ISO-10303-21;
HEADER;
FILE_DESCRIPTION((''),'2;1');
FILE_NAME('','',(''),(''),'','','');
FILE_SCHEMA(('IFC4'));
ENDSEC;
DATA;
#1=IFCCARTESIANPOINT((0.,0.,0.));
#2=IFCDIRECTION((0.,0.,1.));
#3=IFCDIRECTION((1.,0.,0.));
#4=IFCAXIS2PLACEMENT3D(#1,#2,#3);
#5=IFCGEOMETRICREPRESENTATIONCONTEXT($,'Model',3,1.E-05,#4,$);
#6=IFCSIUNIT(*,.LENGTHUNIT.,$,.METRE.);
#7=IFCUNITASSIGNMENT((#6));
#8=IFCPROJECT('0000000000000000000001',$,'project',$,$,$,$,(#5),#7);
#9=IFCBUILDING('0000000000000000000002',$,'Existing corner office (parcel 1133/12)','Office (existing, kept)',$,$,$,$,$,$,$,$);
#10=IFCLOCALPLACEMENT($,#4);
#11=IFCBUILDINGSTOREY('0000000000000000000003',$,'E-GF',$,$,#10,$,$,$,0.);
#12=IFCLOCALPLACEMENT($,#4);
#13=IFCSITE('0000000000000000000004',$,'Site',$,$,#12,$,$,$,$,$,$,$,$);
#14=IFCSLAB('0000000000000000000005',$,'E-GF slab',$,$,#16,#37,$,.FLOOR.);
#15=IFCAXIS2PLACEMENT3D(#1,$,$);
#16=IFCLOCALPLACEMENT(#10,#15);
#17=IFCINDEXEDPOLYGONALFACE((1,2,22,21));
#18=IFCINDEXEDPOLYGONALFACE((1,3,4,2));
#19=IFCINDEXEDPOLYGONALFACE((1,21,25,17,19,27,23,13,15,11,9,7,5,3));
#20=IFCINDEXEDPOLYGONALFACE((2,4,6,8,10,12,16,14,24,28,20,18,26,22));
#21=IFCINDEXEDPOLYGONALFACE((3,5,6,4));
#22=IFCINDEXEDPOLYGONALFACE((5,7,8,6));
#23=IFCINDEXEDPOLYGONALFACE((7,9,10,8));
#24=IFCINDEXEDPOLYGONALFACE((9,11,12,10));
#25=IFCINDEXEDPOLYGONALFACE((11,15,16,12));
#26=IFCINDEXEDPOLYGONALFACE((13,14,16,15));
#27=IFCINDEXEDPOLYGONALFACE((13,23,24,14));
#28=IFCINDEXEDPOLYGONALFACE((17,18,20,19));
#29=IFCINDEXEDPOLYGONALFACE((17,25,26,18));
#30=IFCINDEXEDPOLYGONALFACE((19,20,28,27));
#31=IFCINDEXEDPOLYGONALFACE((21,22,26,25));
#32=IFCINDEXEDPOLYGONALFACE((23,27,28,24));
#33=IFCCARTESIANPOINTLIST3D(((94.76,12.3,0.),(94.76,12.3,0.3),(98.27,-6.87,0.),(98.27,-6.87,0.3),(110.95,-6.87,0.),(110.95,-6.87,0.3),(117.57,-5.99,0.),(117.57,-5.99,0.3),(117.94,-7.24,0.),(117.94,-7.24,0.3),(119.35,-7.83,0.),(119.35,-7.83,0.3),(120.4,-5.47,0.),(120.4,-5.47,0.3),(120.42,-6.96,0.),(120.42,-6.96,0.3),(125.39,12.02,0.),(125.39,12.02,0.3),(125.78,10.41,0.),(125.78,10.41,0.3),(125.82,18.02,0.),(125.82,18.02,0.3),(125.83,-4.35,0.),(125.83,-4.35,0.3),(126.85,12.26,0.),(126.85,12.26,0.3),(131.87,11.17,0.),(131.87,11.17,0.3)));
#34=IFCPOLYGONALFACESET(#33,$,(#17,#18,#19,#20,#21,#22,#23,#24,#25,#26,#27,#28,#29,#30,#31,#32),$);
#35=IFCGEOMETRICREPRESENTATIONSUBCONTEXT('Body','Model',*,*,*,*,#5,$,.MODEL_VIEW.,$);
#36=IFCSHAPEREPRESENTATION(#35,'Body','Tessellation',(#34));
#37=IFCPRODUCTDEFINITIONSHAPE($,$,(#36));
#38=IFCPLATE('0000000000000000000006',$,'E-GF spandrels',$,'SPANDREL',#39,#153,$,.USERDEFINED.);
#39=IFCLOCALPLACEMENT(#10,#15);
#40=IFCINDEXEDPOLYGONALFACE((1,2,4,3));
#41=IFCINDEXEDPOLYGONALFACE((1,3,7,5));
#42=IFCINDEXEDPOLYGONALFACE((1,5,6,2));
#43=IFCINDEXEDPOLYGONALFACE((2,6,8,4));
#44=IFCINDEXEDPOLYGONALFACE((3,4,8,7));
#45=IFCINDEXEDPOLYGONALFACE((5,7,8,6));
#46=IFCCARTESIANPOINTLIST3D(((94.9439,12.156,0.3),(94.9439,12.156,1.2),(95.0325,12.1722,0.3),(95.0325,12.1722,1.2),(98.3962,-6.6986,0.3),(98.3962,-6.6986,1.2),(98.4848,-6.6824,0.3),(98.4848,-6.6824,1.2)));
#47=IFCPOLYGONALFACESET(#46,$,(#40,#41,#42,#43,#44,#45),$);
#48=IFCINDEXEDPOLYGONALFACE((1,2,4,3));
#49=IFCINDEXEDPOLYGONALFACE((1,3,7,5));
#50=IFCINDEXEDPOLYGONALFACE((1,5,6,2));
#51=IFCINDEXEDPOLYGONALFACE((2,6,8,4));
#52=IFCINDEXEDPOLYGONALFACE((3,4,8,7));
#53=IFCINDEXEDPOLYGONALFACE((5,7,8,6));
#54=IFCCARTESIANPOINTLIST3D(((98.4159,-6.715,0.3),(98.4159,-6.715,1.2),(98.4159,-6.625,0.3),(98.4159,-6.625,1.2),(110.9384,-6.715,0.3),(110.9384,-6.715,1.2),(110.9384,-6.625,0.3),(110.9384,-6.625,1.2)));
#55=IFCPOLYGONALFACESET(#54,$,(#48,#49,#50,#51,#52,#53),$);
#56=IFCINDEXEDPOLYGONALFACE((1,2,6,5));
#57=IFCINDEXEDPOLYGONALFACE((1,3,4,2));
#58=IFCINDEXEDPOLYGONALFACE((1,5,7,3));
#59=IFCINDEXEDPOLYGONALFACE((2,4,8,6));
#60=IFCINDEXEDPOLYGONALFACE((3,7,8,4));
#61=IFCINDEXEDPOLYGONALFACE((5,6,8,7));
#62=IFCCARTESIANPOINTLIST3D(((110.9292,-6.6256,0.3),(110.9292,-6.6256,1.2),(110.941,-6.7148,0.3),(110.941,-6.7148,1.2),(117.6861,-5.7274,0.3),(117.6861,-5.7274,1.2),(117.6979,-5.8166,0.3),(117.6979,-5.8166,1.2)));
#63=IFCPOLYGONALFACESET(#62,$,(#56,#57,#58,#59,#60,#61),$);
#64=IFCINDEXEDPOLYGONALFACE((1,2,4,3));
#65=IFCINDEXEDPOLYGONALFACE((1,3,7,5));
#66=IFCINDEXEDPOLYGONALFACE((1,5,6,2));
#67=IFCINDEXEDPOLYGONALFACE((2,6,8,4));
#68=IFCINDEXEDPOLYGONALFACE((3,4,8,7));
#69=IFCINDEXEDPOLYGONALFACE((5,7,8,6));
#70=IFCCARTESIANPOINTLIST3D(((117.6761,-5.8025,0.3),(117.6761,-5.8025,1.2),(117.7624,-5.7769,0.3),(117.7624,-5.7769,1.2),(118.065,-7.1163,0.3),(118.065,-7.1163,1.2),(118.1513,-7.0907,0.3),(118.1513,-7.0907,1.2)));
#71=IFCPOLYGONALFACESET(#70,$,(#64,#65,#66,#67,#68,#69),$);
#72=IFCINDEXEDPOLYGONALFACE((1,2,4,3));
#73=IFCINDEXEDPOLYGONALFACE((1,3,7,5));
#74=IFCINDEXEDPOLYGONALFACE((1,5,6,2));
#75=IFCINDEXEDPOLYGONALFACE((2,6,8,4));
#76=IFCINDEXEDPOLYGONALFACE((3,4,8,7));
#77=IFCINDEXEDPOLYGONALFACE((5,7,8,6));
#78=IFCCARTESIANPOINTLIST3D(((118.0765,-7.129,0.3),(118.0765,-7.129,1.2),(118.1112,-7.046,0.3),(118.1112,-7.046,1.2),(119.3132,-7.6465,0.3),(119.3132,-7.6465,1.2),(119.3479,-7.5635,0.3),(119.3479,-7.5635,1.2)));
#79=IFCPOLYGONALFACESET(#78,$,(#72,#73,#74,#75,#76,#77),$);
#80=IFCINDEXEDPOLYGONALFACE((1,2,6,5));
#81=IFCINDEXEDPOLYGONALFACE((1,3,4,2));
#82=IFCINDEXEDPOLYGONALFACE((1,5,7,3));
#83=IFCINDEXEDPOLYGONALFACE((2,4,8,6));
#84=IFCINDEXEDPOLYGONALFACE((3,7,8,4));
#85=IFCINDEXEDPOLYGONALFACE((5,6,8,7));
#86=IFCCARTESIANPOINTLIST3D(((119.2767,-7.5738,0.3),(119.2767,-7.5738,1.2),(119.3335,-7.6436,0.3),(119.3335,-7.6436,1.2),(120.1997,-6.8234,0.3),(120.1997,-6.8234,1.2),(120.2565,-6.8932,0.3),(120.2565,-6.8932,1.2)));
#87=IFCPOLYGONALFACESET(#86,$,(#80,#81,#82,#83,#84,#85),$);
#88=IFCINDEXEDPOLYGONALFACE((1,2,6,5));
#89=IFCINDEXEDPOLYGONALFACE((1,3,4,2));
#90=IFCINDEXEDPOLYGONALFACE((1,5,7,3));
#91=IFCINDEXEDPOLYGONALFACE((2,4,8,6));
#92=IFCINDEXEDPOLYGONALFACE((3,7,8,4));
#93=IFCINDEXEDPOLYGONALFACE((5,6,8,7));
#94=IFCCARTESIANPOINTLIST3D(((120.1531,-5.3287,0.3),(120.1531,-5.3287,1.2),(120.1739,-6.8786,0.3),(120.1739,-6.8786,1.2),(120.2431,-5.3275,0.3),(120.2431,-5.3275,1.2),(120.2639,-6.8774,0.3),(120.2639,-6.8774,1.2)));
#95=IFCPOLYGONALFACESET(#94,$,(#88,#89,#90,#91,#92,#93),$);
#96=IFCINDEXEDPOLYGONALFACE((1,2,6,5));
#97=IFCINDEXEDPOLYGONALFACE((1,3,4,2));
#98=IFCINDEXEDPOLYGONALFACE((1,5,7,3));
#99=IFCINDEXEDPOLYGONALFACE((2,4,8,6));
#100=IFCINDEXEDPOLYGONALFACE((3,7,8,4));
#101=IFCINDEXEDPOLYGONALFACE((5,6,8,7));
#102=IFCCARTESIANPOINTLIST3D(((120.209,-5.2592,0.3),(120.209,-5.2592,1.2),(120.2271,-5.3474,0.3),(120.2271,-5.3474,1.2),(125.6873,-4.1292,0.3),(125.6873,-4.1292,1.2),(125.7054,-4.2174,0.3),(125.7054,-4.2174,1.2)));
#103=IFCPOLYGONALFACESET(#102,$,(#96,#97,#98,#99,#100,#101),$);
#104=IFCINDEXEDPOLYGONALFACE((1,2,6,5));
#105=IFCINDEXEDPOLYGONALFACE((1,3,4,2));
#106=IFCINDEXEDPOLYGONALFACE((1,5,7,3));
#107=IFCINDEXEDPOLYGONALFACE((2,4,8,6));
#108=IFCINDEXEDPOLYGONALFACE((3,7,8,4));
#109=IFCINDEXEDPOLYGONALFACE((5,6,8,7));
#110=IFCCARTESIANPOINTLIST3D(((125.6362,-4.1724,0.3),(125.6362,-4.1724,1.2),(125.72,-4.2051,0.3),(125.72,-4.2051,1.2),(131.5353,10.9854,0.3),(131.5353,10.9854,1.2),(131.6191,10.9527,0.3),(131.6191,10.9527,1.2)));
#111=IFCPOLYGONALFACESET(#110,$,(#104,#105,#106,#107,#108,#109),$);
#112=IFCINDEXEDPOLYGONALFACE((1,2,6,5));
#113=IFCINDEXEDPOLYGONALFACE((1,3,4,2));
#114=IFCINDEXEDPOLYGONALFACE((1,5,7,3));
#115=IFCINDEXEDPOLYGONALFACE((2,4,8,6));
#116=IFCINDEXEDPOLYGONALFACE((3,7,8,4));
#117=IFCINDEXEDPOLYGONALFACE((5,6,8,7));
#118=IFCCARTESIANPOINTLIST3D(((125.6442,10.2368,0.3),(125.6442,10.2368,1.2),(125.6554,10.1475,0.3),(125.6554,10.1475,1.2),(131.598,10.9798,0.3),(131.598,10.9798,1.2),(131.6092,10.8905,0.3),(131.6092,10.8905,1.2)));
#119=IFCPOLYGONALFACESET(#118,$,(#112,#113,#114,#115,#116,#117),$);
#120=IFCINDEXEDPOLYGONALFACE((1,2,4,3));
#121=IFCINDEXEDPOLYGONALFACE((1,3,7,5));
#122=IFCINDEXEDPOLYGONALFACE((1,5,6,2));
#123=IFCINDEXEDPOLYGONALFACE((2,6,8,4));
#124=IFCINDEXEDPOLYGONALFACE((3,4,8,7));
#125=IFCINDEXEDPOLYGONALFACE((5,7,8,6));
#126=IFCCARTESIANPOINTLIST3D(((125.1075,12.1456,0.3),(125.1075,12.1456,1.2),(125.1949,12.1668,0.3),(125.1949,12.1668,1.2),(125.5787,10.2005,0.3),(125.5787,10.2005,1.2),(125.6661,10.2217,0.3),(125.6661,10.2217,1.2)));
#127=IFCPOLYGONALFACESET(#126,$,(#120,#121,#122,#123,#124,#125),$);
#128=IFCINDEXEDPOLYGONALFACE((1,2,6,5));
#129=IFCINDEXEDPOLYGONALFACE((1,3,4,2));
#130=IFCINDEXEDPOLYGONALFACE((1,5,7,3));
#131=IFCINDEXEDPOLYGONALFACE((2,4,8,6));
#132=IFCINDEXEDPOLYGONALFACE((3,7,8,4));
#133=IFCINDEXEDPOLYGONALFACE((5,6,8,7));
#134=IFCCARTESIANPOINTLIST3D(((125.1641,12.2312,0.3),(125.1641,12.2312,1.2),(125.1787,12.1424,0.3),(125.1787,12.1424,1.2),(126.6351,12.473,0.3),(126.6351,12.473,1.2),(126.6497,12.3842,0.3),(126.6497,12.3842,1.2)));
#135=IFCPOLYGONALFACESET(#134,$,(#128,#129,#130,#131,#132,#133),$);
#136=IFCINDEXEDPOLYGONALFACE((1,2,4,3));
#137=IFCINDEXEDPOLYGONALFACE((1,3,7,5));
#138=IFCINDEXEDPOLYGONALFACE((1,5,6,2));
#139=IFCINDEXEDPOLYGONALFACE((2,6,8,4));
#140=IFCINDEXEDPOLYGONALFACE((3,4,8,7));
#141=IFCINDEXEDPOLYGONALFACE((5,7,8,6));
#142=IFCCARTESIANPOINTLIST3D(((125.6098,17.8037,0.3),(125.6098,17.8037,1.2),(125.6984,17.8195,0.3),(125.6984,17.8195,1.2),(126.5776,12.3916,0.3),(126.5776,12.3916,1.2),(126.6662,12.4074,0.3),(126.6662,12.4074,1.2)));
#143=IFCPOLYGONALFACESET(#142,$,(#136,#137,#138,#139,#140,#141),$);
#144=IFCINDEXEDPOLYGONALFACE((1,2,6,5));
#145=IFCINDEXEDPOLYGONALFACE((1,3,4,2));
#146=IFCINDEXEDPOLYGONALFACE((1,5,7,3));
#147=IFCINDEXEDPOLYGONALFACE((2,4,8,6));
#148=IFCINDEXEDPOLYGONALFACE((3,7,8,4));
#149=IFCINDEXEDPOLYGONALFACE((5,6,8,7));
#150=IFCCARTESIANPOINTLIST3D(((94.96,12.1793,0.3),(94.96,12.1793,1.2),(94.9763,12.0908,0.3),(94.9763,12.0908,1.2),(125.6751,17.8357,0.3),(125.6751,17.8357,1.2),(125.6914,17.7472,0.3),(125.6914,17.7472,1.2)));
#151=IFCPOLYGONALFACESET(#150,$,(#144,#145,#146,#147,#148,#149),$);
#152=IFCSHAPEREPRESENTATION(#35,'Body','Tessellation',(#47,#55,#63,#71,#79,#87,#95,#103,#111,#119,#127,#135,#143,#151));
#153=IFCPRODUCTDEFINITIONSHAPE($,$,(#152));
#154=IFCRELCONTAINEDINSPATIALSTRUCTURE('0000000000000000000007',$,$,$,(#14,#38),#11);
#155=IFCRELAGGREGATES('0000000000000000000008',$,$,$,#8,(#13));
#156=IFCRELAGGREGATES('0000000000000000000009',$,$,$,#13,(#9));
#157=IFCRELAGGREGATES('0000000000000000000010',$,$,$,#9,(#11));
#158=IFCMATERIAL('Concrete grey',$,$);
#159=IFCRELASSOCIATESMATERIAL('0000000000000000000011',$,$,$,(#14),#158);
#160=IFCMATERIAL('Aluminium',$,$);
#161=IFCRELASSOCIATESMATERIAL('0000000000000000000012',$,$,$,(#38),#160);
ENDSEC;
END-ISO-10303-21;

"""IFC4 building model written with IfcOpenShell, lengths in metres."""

from ifc_helpers import new_model, si_unit, frame, origin_with_axes, place, context, subcontext, project, spatial, polyline, outline, extrude, material, element, save


model = new_model("IFC4")

# Units and contexts
model_context = context("Model", 3, precision=1e-05, world=origin_with_axes())
body_context = subcontext(model_context, "Body", "Model", "MODEL_VIEW")
ifc_project = project(units=[si_unit("LENGTHUNIT", "METRE")], contexts=[model_context])

# Site, building, storey
site_placement = place(None, origin_with_axes())
site = spatial("IfcSite", under=ifc_project, at=site_placement, Name="Site")
building = spatial("IfcBuilding", under=site, Name="Existing corner office (parcel 1133/12)", Description="Office (existing, kept)")
storey_placement = place(None, origin_with_axes())
storey = spatial("IfcBuildingStorey", under=building, at=storey_placement, Name="E-GF", Elevation=0.0)

# Shared definitions
ifc_material_1 = material(Name="Aluminium")

# Slab
ifc_material_2 = material(Name="Concrete grey")
slab_placement = place(storey_placement, origin_with_axes())
element("IfcSlab", 1, at=slab_placement, inside=storey, material=ifc_material_2, Name="E-GF slab", PredefinedType="FLOOR", context=body_context, shape_type="SweptSolid", body=[
    extrude(outline(polyline([(94.76, 12.3), (98.27, -6.87), (110.95, -6.87), (117.57, -5.99), (117.94, -7.24), (119.35, -7.83), (120.42, -6.96), (120.4, -5.47), (125.83, -4.35), (131.87, 11.17), (125.78, 10.41), (125.39, 12.02), (126.85, 12.26), (125.82, 18.02), (94.76, 12.3)])), origin_with_axes(), (0.0, 0.0, 1.0), 0.3),
])

# Plate
plate_placement = place(storey_placement, origin_with_axes())
element("IfcPlate", 2, at=plate_placement, inside=storey, material=ifc_material_1, Name="E-GF spandrels", ObjectType="SPANDREL", PredefinedType="USERDEFINED", context=body_context, shape_type="SweptSolid", body=[
    extrude(outline(polyline([(94.9439, 12.156), (98.3962, -6.6986), (98.4848, -6.6824), (95.0325, 12.1722), (94.9439, 12.156)])), frame((0.0, 0.0, 0.3), z_axis=(0.0, 0.0, 1.0), x_axis=(1.0, 0.0, 0.0)), (0.0, 0.0, 1.0), 0.9),
    extrude(outline(polyline([(98.4159, -6.715), (110.9384, -6.715), (110.9384, -6.625), (98.4159, -6.625), (98.4159, -6.715)])), frame((0.0, 0.0, 0.3), z_axis=(0.0, 0.0, 1.0), x_axis=(1.0, 0.0, 0.0)), (0.0, 0.0, 1.0), 0.9),
    extrude(outline(polyline([(110.941, -6.7148), (117.6979, -5.8166), (117.6861, -5.7274), (110.9292, -6.6256), (110.941, -6.7148)])), frame((0.0, 0.0, 0.3), z_axis=(0.0, 0.0, 1.0), x_axis=(1.0, 0.0, 0.0)), (0.0, 0.0, 1.0), 0.9),
    extrude(outline(polyline([(117.6761, -5.8025), (118.065, -7.1163), (118.1513, -7.0907), (117.7624, -5.7769), (117.6761, -5.8025)])), frame((0.0, 0.0, 0.3), z_axis=(0.0, 0.0, 1.0), x_axis=(1.0, 0.0, 0.0)), (0.0, 0.0, 1.0), 0.9),
    extrude(outline(polyline([(118.0765, -7.129), (119.3132, -7.6465), (119.3479, -7.5635), (118.1112, -7.046), (118.0765, -7.129)])), frame((0.0, 0.0, 0.3), z_axis=(0.0, 0.0, 1.0), x_axis=(1.0, 0.0, 0.0)), (0.0, 0.0, 1.0), 0.9),
    extrude(outline(polyline([(119.3335, -7.6436), (120.2565, -6.8932), (120.1997, -6.8234), (119.2767, -7.5738), (119.3335, -7.6436)])), frame((0.0, 0.0, 0.3), z_axis=(0.0, 0.0, 1.0), x_axis=(1.0, 0.0, 0.0)), (0.0, 0.0, 1.0), 0.9),
    extrude(outline(polyline([(120.2639, -6.8774), (120.2431, -5.3275), (120.1531, -5.3287), (120.1739, -6.8786), (120.2639, -6.8774)])), frame((0.0, 0.0, 0.3), z_axis=(0.0, 0.0, 1.0), x_axis=(1.0, 0.0, 0.0)), (0.0, 0.0, 1.0), 0.9),
    extrude(outline(polyline([(120.2271, -5.3474), (125.7054, -4.2174), (125.6873, -4.1292), (120.209, -5.2592), (120.2271, -5.3474)])), frame((0.0, 0.0, 0.3), z_axis=(0.0, 0.0, 1.0), x_axis=(1.0, 0.0, 0.0)), (0.0, 0.0, 1.0), 0.9),
    extrude(outline(polyline([(125.72, -4.2051), (131.6191, 10.9527), (131.5353, 10.9854), (125.6362, -4.1724), (125.72, -4.2051)])), frame((0.0, 0.0, 0.3), z_axis=(0.0, 0.0, 1.0), x_axis=(1.0, 0.0, 0.0)), (0.0, 0.0, 1.0), 0.9),
    extrude(outline(polyline([(131.598, 10.9798), (125.6442, 10.2368), (125.6554, 10.1475), (131.6092, 10.8905), (131.598, 10.9798)])), frame((0.0, 0.0, 0.3), z_axis=(0.0, 0.0, 1.0), x_axis=(1.0, 0.0, 0.0)), (0.0, 0.0, 1.0), 0.9),
    extrude(outline(polyline([(125.6661, 10.2217), (125.1949, 12.1668), (125.1075, 12.1456), (125.5787, 10.2005), (125.6661, 10.2217)])), frame((0.0, 0.0, 0.3), z_axis=(0.0, 0.0, 1.0), x_axis=(1.0, 0.0, 0.0)), (0.0, 0.0, 1.0), 0.9),
    extrude(outline(polyline([(125.1787, 12.1424), (126.6497, 12.3842), (126.6351, 12.473), (125.1641, 12.2312), (125.1787, 12.1424)])), frame((0.0, 0.0, 0.3), z_axis=(0.0, 0.0, 1.0), x_axis=(1.0, 0.0, 0.0)), (0.0, 0.0, 1.0), 0.9),
    extrude(outline(polyline([(126.6662, 12.4074), (125.6984, 17.8195), (125.6098, 17.8037), (126.5776, 12.3916), (126.6662, 12.4074)])), frame((0.0, 0.0, 0.3), z_axis=(0.0, 0.0, 1.0), x_axis=(1.0, 0.0, 0.0)), (0.0, 0.0, 1.0), 0.9),
    extrude(outline(polyline([(125.6751, 17.8357), (94.96, 12.1793), (94.9763, 12.0908), (125.6914, 17.7472), (125.6751, 17.8357)])), frame((0.0, 0.0, 0.3), z_axis=(0.0, 0.0, 1.0), x_axis=(1.0, 0.0, 0.0)), (0.0, 0.0, 1.0), 0.9),
])

save(model, "model.ifc")
